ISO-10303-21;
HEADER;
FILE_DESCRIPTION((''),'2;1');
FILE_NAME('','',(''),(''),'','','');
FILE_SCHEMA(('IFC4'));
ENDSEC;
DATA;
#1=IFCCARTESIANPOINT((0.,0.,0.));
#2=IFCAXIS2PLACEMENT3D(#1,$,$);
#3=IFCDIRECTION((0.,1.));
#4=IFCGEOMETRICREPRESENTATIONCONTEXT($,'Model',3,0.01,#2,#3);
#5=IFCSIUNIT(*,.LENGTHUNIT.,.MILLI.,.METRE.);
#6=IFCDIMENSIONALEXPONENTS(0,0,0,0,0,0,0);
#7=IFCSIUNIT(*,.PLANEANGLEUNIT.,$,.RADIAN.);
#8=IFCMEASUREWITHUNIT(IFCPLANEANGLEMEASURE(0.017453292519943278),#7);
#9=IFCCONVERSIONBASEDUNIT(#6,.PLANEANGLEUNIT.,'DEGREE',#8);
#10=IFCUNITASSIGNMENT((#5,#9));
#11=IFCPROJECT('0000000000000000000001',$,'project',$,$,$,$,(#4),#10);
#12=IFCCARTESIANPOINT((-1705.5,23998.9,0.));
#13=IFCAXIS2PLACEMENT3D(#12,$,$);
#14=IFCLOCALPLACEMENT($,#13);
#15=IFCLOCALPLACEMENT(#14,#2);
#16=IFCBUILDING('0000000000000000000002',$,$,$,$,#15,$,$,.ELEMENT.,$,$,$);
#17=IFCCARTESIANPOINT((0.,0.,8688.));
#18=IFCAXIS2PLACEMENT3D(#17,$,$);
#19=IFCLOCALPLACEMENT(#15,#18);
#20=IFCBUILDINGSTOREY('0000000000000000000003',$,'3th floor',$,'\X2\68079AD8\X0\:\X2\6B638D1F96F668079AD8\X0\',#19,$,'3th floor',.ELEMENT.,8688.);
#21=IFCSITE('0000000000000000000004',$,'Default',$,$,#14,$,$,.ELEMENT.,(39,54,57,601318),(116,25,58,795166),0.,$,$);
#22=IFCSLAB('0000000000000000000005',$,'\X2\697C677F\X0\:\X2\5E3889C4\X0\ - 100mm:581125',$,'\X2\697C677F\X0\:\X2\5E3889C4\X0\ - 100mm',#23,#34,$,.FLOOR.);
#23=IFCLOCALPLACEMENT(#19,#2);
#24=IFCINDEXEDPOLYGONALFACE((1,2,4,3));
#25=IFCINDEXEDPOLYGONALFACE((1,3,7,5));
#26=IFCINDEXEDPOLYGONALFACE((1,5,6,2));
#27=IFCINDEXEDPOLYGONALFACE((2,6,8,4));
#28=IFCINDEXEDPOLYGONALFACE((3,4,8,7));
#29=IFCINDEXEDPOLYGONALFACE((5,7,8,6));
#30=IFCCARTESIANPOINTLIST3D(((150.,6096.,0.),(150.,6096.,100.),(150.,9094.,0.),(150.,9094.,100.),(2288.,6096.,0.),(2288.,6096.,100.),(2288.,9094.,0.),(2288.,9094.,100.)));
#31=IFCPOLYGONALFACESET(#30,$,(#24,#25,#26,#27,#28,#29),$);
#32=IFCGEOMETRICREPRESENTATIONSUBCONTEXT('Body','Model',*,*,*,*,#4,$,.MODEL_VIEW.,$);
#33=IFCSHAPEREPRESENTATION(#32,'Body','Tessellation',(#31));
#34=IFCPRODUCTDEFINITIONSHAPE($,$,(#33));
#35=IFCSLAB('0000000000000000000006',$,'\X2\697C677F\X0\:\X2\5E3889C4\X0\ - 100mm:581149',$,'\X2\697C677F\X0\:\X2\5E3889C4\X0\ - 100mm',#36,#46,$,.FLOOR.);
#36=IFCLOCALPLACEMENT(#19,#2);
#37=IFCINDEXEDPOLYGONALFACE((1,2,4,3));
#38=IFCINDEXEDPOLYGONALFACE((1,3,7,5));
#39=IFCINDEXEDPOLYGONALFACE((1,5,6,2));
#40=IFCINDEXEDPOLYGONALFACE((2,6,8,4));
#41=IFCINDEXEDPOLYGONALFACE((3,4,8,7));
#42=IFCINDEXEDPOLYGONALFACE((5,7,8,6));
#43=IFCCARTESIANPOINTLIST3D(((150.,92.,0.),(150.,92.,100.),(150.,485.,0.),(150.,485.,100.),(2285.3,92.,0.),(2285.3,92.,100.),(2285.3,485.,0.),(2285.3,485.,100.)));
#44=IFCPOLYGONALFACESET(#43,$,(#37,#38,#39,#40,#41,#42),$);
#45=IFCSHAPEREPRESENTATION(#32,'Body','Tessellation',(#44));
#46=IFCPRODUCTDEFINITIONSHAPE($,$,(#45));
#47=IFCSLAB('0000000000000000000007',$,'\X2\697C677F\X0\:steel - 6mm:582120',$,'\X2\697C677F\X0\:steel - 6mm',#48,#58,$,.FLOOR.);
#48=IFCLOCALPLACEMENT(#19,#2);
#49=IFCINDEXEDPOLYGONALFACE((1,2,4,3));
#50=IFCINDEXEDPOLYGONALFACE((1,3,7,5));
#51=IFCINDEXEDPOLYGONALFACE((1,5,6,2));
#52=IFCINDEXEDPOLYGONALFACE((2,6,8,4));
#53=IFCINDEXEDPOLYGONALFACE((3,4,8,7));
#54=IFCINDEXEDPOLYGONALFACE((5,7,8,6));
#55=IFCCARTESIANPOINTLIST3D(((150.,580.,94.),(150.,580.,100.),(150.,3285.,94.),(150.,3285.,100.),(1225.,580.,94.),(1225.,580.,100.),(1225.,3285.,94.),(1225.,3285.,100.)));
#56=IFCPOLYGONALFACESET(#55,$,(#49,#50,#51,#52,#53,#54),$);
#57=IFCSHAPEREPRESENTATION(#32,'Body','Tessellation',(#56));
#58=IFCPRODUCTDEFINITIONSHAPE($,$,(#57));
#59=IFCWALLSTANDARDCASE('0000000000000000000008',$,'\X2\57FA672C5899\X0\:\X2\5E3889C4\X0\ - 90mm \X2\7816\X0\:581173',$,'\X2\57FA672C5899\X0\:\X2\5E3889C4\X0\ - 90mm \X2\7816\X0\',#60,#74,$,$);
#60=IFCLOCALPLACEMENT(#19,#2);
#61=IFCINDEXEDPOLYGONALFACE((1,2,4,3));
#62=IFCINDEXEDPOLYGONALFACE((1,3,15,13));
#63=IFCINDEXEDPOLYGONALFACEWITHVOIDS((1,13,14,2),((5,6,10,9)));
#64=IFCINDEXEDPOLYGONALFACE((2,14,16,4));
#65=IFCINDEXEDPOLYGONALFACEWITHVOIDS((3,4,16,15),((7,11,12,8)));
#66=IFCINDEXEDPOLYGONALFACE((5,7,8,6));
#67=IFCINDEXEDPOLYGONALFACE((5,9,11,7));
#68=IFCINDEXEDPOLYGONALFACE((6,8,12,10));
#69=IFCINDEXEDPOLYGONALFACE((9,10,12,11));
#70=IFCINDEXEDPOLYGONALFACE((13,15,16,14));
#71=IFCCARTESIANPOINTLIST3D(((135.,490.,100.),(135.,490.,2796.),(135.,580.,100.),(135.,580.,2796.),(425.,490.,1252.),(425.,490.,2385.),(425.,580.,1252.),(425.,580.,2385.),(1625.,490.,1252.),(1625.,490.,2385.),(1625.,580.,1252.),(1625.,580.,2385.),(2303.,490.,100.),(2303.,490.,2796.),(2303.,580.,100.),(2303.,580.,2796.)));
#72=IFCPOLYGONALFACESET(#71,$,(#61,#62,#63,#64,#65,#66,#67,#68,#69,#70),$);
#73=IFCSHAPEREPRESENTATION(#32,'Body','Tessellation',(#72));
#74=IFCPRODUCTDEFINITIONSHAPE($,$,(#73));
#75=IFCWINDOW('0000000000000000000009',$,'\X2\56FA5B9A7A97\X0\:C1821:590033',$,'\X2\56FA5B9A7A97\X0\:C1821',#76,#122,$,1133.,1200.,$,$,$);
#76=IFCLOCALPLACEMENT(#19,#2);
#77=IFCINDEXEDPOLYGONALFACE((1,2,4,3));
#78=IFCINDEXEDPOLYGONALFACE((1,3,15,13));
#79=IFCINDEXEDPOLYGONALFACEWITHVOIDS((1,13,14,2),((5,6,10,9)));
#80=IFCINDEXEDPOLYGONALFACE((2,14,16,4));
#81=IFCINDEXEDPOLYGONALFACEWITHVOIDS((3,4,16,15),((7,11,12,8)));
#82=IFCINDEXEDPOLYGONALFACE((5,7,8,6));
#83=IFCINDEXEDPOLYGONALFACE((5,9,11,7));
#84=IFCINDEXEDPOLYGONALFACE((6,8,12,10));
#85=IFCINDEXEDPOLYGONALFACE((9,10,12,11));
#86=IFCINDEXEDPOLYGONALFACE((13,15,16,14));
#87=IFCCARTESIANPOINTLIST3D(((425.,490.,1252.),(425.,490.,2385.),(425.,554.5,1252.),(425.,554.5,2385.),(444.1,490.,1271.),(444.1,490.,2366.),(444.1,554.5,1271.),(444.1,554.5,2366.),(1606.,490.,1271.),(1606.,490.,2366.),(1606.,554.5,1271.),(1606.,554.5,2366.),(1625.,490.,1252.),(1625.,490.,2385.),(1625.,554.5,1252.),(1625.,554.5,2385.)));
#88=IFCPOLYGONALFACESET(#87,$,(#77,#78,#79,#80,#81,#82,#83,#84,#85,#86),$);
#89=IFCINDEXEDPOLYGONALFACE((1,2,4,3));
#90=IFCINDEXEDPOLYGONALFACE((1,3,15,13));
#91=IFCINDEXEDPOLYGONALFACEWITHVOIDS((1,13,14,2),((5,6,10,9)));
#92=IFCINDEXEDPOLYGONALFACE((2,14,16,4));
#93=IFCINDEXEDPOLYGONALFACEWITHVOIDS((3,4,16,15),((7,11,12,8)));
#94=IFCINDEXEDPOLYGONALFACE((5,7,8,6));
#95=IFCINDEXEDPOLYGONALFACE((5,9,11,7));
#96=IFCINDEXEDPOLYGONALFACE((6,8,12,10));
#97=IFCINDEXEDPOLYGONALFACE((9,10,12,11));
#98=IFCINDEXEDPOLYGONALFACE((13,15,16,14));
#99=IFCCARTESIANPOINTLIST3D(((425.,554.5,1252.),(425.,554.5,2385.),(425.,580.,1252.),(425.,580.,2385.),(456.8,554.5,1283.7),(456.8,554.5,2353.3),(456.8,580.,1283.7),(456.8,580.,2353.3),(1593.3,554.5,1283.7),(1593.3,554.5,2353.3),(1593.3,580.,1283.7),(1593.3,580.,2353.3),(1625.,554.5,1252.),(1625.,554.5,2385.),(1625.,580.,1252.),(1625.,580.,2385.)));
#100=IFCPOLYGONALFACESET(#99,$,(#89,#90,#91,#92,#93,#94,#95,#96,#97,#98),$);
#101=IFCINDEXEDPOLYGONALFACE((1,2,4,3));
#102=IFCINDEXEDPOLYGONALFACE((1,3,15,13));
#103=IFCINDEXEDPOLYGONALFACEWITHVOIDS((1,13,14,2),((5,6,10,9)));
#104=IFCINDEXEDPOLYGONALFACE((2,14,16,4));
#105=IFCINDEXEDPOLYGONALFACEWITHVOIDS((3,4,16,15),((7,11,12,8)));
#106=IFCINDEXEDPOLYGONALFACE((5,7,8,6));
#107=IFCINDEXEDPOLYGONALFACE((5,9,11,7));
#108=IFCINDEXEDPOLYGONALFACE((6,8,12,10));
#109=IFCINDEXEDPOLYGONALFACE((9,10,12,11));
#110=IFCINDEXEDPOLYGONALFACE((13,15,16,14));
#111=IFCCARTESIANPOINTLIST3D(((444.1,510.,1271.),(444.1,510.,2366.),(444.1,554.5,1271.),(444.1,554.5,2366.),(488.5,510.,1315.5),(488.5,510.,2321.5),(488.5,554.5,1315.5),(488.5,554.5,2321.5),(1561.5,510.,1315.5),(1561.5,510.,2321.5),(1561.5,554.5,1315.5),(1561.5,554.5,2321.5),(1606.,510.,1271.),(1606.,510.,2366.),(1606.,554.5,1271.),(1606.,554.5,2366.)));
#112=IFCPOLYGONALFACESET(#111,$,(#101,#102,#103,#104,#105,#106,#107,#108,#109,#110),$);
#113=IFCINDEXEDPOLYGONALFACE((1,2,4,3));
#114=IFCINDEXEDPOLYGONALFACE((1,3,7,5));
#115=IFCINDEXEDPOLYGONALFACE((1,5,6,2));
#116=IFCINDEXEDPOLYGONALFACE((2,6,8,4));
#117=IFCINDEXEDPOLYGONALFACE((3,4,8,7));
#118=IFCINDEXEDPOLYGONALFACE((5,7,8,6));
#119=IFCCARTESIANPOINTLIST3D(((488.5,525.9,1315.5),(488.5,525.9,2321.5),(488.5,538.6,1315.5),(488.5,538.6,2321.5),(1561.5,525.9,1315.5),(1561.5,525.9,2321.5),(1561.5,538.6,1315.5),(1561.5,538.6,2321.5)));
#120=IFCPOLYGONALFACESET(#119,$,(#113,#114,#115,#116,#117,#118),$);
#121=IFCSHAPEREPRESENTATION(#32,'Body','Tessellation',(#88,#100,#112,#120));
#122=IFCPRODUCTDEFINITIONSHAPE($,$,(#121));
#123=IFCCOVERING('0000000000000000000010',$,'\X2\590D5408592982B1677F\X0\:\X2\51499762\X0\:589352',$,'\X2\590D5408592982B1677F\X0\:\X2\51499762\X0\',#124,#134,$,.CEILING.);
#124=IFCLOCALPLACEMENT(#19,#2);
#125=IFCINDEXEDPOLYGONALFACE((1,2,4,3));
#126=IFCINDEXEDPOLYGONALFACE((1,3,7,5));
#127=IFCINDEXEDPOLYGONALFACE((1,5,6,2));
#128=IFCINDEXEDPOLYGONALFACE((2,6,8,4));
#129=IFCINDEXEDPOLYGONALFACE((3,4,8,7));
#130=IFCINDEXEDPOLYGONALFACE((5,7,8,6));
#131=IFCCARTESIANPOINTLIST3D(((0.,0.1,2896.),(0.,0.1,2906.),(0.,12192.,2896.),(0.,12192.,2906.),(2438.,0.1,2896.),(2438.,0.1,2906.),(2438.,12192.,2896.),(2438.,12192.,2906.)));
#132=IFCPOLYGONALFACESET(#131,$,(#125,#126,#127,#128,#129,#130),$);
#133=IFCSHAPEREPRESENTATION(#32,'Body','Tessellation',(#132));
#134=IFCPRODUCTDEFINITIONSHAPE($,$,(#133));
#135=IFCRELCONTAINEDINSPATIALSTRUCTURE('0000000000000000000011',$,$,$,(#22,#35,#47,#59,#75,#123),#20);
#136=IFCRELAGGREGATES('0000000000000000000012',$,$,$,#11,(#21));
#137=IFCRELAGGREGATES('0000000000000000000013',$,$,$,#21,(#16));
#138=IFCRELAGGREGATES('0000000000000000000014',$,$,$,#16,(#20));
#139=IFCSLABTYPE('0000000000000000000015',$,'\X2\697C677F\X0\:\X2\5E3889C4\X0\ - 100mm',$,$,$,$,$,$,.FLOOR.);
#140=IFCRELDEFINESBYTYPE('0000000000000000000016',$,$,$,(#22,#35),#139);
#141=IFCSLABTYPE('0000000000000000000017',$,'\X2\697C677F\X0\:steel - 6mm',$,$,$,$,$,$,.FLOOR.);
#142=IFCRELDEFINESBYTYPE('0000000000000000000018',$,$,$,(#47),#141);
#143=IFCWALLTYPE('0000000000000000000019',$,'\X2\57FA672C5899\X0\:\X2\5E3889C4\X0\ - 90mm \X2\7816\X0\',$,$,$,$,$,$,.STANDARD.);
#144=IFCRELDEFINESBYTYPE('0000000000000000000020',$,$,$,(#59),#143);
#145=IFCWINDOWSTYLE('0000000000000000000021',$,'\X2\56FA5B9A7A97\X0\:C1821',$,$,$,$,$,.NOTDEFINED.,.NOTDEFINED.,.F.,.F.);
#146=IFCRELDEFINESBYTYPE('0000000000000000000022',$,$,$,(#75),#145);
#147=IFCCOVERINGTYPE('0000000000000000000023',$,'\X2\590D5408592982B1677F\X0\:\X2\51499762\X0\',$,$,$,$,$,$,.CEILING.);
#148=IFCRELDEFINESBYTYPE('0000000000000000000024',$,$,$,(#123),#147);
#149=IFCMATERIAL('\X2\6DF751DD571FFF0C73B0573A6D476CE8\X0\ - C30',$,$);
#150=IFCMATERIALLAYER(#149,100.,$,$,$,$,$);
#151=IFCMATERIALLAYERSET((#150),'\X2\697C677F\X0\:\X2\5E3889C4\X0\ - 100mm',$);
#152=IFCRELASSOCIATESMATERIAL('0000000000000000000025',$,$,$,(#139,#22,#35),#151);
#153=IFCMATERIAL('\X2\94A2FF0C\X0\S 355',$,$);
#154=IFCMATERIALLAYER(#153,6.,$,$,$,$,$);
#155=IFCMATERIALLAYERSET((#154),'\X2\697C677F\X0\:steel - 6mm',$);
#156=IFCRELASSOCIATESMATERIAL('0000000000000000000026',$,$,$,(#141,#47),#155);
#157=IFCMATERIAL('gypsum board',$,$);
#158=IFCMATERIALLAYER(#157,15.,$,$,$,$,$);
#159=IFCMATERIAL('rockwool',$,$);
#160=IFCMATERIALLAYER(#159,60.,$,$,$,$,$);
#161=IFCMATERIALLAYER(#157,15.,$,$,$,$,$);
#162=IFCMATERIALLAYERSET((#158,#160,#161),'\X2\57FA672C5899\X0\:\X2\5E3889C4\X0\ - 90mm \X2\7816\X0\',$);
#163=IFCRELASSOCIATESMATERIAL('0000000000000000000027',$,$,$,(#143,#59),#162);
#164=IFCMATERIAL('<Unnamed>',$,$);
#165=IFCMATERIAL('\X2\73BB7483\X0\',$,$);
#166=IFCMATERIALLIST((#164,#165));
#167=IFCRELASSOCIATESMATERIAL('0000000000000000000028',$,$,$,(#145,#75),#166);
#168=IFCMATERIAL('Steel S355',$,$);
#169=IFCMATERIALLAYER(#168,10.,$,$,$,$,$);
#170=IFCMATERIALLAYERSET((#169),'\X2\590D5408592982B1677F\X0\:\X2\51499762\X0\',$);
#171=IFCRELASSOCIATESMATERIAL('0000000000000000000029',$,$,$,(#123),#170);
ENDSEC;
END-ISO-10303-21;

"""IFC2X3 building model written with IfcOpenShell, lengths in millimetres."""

from ifc_helpers import new_model, entity, si_unit, converted_unit, direction, frame, frame_2d, origin, origin_2d_with_axis, place, context, subcontext, project, spatial, polyline, rectangle, outline, extrude, source, transform, mapped, material, material_list, layer, layer_set, layer_usage, type_object, type_shapes, element, fill, save


model = new_model("IFC2X3")

# Units and contexts
model_context = context("Model", 3, precision=0.01, world=origin(), true_north=direction((0.0, 1.0)))
body_context = subcontext(model_context, "Body", "Model", "MODEL_VIEW")
ifc_project = project(units=[si_unit("LENGTHUNIT", "METRE", prefix="MILLI"), converted_unit("PLANEANGLEUNIT", "DEGREE", entity("IfcPlaneAngleMeasure", 0.017453292519943278), si_unit("PLANEANGLEUNIT", "RADIAN"), dimensions=[0, 0, 0, 0, 0, 0, 0])], contexts=[model_context])

# Site, building, storey
site_placement = place(None, frame((-1705.5, 23998.9, 0.0)))
site = spatial("IfcSite", under=ifc_project, at=site_placement, Name="Default", CompositionType="ELEMENT", RefLatitude=(39, 54, 57, 601318), RefLongitude=(116, 25, 58, 795166), RefElevation=0.0)
building_placement = place(site_placement, origin())
building = spatial("IfcBuilding", under=site, at=building_placement, CompositionType="ELEMENT")
storey_placement = place(building_placement, frame((0.0, 0.0, 8688.0)))
storey = spatial("IfcBuildingStorey", under=building, at=storey_placement, Name="3th floor", ObjectType="标高:正负零标高", LongName="3th floor", CompositionType="ELEMENT", Elevation=8688.0)

# Shared definitions
ifc_material_1 = material(Name="Steel S355")

# Slabs
ifc_material_2 = material(Name="混凝土，现场浇注 - C30")
ifc_layer_1 = layer(ifc_material_2, 100.0)
ifc_layer_set_1 = layer_set([ifc_layer_1], Name="楼板:常规 - 100mm")
slab_type_1 = type_object("IfcSlabType", Name="楼板:常规 - 100mm", PredefinedType="FLOOR", material=ifc_layer_set_1)
ifc_layer_usage_1 = layer_usage(ifc_layer_set_1, "AXIS3", "POSITIVE", 0.0)
slab_1_placement = place(storey_placement, origin())
element("IfcSlab", 1, at=slab_1_placement, inside=storey, type_object=slab_type_1, material=ifc_layer_usage_1, Name="楼板:常规 - 100mm:581125", ObjectType="楼板:常规 - 100mm", PredefinedType="FLOOR", context=body_context, shape_type="SweptSolid", body=[
    extrude(rectangle(XDim=2998.0, YDim=2138.0, at=origin_2d_with_axis()), frame((1219.0, 7595.0, 100.0), z_axis=(0.0, 0.0, -1.0), x_axis=(0.0, 1.0, 0.0)), (0.0, 0.0, 1.0), 100.0),
])
ifc_layer_usage_2 = layer_usage(ifc_layer_set_1, "AXIS3", "POSITIVE", 0.0)
slab_2_placement = place(storey_placement, origin())
element("IfcSlab", 2, at=slab_2_placement, inside=storey, type_object=slab_type_1, material=ifc_layer_usage_2, Name="楼板:常规 - 100mm:581149", ObjectType="楼板:常规 - 100mm", PredefinedType="FLOOR", context=body_context, shape_type="SweptSolid", body=[
    extrude(rectangle(XDim=393.0, YDim=2135.3, at=frame_2d((0.0, 0.0), x_axis=(1.0, 0.0))), frame((1217.7, 288.5, 100.0), z_axis=(0.0, 0.0, -1.0), x_axis=(0.0, 1.0, 0.0)), (0.0, 0.0, 1.0), 100.0),
])
ifc_material_3 = material(Name="钢，S 355")
ifc_layer_2 = layer(ifc_material_3, 6.0)
ifc_layer_set_2 = layer_set([ifc_layer_2], Name="楼板:steel - 6mm")
ifc_layer_usage_3 = layer_usage(ifc_layer_set_2, "AXIS3", "POSITIVE", 0.0)
slab_type_2 = type_object("IfcSlabType", Name="楼板:steel - 6mm", PredefinedType="FLOOR", material=ifc_layer_set_2)
slab_3_placement = place(storey_placement, origin())
element("IfcSlab", 3, at=slab_3_placement, inside=storey, type_object=slab_type_2, material=ifc_layer_usage_3, Name="楼板:steel - 6mm:582120", ObjectType="楼板:steel - 6mm", PredefinedType="FLOOR", context=body_context, shape_type="SweptSolid", body=[
    extrude(rectangle(XDim=2705.0, YDim=1075.0, at=origin_2d_with_axis()), frame((687.5, 1932.5, 100.0), z_axis=(0.0, 0.0, -1.0), x_axis=(0.0, 1.0, 0.0)), (0.0, 0.0, 1.0), 6.0),
])

# Wall, opening, window
ifc_material_4 = material(Name="gypsum board")
ifc_layer_3 = layer(ifc_material_4, 15.0)
ifc_material_5 = material(Name="rockwool")
ifc_layer_4 = layer(ifc_material_5, 60.0)
ifc_layer_5 = layer(ifc_material_4, 15.0)
ifc_layer_set_3 = layer_set([ifc_layer_3, ifc_layer_4, ifc_layer_5], Name="基本墙:常规 - 90mm 砖")
ifc_layer_usage_4 = layer_usage(ifc_layer_set_3, "AXIS2", "NEGATIVE", 45.0)
wall_type = type_object("IfcWallType", Name="基本墙:常规 - 90mm 砖", PredefinedType="STANDARD", material=ifc_layer_set_3)
wall_placement = place(storey_placement, frame((2303.0, 535.0, 100.0), z_axis=(0.0, 0.0, 1.0), x_axis=(-1.0, 0.0, 0.0)))
wall = element("IfcWallStandardCase", 4, at=wall_placement, inside=storey, type_object=wall_type, material=ifc_layer_usage_4, Name="基本墙:常规 - 90mm 砖:581173", ObjectType="基本墙:常规 - 90mm 砖", context=body_context, shape_type="SweptSolid", body=[
    extrude(rectangle(XDim=2168.0, YDim=90.0, at=frame_2d((1084.0, 0.0), x_axis=(-1.0, 0.0))), origin(), (0.0, 0.0, 1.0), 2696.0),
])
opening_1_placement = place(wall_placement, frame((678.0, -45.0, 1152.0)))
opening_1 = element("IfcOpeningElement", 5, at=opening_1_placement, cuts=wall, ObjectType="Opening", context=body_context, shape_type="SweptSolid", body=[
    extrude(rectangle(XDim=1133.0, YDim=1200.0, at=frame_2d((566.5, 600.0), x_axis=(-1.0, 0.0))), frame((0.0, 0.0, 0.0), z_axis=(0.0, 1.0, 0.0), x_axis=(0.0, 0.0, 1.0)), (0.0, 0.0, 1.0), 90.0),
])
ifc_material_6 = material(Name="<Unnamed>")
ifc_material_7 = material(Name="玻璃")
ifc_material_list_1 = material_list([ifc_material_6, ifc_material_7])
window_style = type_object("IfcWindowStyle", Name="固定窗:C1821", ConstructionType="NOTDEFINED", OperationType="NOTDEFINED", ParameterTakesPrecedence=False, Sizeable=False, material=ifc_material_list_1)
shared_shape = source(origin(), body_context, "Body", "SweptSolid", [
    extrude(outline(polyline([(-566.5, -600.0), (566.5, -600.0), (566.5, 600.0), (-566.5, 600.0), (-566.5, -600.0)]), holes=[polyline([(-547.4, -580.9), (-547.4, 581.0), (547.5, 581.0), (547.5, -580.9), (-547.4, -580.9)])]), frame((676.2, 90.0, 566.5), z_axis=(0.0, -1.0, 0.0), x_axis=(0.0, 0.0, -1.0)), (0.0, 0.0, 1.0), 64.4),
    extrude(outline(polyline([(-600.0, -566.5), (600.0, -566.5), (600.0, 566.5), (-600.0, 566.5), (-600.0, -566.5)]), holes=[polyline([(-568.3, -534.7), (-568.3, 534.8), (568.2, 534.8), (568.2, -534.7), (-568.3, -534.7)])]), frame((676.2, 25.5, 566.5), z_axis=(0.0, -1.0, 0.0), x_axis=(-1.0, 0.0, 0.0)), (0.0, 0.0, 1.0), 25.5),
    extrude(outline(polyline([(-580.9, -547.5), (580.9, -547.5), (580.9, 547.5), (-580.9, 547.5), (-580.9, -547.5)]), holes=[polyline([(-536.5, -503.0), (-536.5, 503.0), (536.5, 503.0), (536.5, -503.0), (-536.5, -503.0)])]), frame((676.2, 70.0, 566.5), z_axis=(0.0, -1.0, 0.0), x_axis=(-1.0, 0.0, 0.0)), (0.0, 0.0, 1.0), 44.4),
    extrude(rectangle(XDim=1073.0, YDim=12.7, at=origin_2d_with_axis()), frame((676.2, 47.8, 63.5)), (0.0, 0.0, 1.0), 1006.0),
])
type_shapes(window_style, [shared_shape])
window_placement = place(opening_1_placement, frame((-76.2, 0.0, 0.0)))
window = element("IfcWindow", 6, at=window_placement, inside=storey, type_object=window_style, material=ifc_material_list_1, Name="固定窗:C1821:590033", ObjectType="固定窗:C1821", OverallHeight=1133.0, OverallWidth=1200.0, context=body_context, shape_type="MappedRepresentation", body=[
    mapped(shared_shape, transform((0.0, 0.0, 0.0), scale=1.0)),
])
fill(opening_1, window)

# Covering
ifc_layer_6 = layer(ifc_material_1, 10.0)
ifc_layer_set_4 = layer_set([ifc_layer_6], Name="复合天花板:光面")
ifc_layer_usage_5 = layer_usage(ifc_layer_set_4, "AXIS3", "NEGATIVE", 10.0)
covering_type = type_object("IfcCoveringType", Name="复合天花板:光面", PredefinedType="CEILING")
covering_placement = place(storey_placement, origin())
element("IfcCovering", 7, at=covering_placement, inside=storey, type_object=covering_type, material=ifc_layer_usage_5, Name="复合天花板:光面:589352", ObjectType="复合天花板:光面", PredefinedType="CEILING", context=body_context, shape_type="SweptSolid", body=[
    extrude(rectangle(XDim=12191.9, YDim=2438.0, at=frame_2d((0.0, 0.0), x_axis=(1.0, 0.0))), frame((1219.0, 6096.0, 2896.0), z_axis=(0.0, 0.0, 1.0), x_axis=(0.0, 1.0, 0.0)), (0.0, 0.0, 1.0), 10.0),
])

save(model, "model.ifc")
